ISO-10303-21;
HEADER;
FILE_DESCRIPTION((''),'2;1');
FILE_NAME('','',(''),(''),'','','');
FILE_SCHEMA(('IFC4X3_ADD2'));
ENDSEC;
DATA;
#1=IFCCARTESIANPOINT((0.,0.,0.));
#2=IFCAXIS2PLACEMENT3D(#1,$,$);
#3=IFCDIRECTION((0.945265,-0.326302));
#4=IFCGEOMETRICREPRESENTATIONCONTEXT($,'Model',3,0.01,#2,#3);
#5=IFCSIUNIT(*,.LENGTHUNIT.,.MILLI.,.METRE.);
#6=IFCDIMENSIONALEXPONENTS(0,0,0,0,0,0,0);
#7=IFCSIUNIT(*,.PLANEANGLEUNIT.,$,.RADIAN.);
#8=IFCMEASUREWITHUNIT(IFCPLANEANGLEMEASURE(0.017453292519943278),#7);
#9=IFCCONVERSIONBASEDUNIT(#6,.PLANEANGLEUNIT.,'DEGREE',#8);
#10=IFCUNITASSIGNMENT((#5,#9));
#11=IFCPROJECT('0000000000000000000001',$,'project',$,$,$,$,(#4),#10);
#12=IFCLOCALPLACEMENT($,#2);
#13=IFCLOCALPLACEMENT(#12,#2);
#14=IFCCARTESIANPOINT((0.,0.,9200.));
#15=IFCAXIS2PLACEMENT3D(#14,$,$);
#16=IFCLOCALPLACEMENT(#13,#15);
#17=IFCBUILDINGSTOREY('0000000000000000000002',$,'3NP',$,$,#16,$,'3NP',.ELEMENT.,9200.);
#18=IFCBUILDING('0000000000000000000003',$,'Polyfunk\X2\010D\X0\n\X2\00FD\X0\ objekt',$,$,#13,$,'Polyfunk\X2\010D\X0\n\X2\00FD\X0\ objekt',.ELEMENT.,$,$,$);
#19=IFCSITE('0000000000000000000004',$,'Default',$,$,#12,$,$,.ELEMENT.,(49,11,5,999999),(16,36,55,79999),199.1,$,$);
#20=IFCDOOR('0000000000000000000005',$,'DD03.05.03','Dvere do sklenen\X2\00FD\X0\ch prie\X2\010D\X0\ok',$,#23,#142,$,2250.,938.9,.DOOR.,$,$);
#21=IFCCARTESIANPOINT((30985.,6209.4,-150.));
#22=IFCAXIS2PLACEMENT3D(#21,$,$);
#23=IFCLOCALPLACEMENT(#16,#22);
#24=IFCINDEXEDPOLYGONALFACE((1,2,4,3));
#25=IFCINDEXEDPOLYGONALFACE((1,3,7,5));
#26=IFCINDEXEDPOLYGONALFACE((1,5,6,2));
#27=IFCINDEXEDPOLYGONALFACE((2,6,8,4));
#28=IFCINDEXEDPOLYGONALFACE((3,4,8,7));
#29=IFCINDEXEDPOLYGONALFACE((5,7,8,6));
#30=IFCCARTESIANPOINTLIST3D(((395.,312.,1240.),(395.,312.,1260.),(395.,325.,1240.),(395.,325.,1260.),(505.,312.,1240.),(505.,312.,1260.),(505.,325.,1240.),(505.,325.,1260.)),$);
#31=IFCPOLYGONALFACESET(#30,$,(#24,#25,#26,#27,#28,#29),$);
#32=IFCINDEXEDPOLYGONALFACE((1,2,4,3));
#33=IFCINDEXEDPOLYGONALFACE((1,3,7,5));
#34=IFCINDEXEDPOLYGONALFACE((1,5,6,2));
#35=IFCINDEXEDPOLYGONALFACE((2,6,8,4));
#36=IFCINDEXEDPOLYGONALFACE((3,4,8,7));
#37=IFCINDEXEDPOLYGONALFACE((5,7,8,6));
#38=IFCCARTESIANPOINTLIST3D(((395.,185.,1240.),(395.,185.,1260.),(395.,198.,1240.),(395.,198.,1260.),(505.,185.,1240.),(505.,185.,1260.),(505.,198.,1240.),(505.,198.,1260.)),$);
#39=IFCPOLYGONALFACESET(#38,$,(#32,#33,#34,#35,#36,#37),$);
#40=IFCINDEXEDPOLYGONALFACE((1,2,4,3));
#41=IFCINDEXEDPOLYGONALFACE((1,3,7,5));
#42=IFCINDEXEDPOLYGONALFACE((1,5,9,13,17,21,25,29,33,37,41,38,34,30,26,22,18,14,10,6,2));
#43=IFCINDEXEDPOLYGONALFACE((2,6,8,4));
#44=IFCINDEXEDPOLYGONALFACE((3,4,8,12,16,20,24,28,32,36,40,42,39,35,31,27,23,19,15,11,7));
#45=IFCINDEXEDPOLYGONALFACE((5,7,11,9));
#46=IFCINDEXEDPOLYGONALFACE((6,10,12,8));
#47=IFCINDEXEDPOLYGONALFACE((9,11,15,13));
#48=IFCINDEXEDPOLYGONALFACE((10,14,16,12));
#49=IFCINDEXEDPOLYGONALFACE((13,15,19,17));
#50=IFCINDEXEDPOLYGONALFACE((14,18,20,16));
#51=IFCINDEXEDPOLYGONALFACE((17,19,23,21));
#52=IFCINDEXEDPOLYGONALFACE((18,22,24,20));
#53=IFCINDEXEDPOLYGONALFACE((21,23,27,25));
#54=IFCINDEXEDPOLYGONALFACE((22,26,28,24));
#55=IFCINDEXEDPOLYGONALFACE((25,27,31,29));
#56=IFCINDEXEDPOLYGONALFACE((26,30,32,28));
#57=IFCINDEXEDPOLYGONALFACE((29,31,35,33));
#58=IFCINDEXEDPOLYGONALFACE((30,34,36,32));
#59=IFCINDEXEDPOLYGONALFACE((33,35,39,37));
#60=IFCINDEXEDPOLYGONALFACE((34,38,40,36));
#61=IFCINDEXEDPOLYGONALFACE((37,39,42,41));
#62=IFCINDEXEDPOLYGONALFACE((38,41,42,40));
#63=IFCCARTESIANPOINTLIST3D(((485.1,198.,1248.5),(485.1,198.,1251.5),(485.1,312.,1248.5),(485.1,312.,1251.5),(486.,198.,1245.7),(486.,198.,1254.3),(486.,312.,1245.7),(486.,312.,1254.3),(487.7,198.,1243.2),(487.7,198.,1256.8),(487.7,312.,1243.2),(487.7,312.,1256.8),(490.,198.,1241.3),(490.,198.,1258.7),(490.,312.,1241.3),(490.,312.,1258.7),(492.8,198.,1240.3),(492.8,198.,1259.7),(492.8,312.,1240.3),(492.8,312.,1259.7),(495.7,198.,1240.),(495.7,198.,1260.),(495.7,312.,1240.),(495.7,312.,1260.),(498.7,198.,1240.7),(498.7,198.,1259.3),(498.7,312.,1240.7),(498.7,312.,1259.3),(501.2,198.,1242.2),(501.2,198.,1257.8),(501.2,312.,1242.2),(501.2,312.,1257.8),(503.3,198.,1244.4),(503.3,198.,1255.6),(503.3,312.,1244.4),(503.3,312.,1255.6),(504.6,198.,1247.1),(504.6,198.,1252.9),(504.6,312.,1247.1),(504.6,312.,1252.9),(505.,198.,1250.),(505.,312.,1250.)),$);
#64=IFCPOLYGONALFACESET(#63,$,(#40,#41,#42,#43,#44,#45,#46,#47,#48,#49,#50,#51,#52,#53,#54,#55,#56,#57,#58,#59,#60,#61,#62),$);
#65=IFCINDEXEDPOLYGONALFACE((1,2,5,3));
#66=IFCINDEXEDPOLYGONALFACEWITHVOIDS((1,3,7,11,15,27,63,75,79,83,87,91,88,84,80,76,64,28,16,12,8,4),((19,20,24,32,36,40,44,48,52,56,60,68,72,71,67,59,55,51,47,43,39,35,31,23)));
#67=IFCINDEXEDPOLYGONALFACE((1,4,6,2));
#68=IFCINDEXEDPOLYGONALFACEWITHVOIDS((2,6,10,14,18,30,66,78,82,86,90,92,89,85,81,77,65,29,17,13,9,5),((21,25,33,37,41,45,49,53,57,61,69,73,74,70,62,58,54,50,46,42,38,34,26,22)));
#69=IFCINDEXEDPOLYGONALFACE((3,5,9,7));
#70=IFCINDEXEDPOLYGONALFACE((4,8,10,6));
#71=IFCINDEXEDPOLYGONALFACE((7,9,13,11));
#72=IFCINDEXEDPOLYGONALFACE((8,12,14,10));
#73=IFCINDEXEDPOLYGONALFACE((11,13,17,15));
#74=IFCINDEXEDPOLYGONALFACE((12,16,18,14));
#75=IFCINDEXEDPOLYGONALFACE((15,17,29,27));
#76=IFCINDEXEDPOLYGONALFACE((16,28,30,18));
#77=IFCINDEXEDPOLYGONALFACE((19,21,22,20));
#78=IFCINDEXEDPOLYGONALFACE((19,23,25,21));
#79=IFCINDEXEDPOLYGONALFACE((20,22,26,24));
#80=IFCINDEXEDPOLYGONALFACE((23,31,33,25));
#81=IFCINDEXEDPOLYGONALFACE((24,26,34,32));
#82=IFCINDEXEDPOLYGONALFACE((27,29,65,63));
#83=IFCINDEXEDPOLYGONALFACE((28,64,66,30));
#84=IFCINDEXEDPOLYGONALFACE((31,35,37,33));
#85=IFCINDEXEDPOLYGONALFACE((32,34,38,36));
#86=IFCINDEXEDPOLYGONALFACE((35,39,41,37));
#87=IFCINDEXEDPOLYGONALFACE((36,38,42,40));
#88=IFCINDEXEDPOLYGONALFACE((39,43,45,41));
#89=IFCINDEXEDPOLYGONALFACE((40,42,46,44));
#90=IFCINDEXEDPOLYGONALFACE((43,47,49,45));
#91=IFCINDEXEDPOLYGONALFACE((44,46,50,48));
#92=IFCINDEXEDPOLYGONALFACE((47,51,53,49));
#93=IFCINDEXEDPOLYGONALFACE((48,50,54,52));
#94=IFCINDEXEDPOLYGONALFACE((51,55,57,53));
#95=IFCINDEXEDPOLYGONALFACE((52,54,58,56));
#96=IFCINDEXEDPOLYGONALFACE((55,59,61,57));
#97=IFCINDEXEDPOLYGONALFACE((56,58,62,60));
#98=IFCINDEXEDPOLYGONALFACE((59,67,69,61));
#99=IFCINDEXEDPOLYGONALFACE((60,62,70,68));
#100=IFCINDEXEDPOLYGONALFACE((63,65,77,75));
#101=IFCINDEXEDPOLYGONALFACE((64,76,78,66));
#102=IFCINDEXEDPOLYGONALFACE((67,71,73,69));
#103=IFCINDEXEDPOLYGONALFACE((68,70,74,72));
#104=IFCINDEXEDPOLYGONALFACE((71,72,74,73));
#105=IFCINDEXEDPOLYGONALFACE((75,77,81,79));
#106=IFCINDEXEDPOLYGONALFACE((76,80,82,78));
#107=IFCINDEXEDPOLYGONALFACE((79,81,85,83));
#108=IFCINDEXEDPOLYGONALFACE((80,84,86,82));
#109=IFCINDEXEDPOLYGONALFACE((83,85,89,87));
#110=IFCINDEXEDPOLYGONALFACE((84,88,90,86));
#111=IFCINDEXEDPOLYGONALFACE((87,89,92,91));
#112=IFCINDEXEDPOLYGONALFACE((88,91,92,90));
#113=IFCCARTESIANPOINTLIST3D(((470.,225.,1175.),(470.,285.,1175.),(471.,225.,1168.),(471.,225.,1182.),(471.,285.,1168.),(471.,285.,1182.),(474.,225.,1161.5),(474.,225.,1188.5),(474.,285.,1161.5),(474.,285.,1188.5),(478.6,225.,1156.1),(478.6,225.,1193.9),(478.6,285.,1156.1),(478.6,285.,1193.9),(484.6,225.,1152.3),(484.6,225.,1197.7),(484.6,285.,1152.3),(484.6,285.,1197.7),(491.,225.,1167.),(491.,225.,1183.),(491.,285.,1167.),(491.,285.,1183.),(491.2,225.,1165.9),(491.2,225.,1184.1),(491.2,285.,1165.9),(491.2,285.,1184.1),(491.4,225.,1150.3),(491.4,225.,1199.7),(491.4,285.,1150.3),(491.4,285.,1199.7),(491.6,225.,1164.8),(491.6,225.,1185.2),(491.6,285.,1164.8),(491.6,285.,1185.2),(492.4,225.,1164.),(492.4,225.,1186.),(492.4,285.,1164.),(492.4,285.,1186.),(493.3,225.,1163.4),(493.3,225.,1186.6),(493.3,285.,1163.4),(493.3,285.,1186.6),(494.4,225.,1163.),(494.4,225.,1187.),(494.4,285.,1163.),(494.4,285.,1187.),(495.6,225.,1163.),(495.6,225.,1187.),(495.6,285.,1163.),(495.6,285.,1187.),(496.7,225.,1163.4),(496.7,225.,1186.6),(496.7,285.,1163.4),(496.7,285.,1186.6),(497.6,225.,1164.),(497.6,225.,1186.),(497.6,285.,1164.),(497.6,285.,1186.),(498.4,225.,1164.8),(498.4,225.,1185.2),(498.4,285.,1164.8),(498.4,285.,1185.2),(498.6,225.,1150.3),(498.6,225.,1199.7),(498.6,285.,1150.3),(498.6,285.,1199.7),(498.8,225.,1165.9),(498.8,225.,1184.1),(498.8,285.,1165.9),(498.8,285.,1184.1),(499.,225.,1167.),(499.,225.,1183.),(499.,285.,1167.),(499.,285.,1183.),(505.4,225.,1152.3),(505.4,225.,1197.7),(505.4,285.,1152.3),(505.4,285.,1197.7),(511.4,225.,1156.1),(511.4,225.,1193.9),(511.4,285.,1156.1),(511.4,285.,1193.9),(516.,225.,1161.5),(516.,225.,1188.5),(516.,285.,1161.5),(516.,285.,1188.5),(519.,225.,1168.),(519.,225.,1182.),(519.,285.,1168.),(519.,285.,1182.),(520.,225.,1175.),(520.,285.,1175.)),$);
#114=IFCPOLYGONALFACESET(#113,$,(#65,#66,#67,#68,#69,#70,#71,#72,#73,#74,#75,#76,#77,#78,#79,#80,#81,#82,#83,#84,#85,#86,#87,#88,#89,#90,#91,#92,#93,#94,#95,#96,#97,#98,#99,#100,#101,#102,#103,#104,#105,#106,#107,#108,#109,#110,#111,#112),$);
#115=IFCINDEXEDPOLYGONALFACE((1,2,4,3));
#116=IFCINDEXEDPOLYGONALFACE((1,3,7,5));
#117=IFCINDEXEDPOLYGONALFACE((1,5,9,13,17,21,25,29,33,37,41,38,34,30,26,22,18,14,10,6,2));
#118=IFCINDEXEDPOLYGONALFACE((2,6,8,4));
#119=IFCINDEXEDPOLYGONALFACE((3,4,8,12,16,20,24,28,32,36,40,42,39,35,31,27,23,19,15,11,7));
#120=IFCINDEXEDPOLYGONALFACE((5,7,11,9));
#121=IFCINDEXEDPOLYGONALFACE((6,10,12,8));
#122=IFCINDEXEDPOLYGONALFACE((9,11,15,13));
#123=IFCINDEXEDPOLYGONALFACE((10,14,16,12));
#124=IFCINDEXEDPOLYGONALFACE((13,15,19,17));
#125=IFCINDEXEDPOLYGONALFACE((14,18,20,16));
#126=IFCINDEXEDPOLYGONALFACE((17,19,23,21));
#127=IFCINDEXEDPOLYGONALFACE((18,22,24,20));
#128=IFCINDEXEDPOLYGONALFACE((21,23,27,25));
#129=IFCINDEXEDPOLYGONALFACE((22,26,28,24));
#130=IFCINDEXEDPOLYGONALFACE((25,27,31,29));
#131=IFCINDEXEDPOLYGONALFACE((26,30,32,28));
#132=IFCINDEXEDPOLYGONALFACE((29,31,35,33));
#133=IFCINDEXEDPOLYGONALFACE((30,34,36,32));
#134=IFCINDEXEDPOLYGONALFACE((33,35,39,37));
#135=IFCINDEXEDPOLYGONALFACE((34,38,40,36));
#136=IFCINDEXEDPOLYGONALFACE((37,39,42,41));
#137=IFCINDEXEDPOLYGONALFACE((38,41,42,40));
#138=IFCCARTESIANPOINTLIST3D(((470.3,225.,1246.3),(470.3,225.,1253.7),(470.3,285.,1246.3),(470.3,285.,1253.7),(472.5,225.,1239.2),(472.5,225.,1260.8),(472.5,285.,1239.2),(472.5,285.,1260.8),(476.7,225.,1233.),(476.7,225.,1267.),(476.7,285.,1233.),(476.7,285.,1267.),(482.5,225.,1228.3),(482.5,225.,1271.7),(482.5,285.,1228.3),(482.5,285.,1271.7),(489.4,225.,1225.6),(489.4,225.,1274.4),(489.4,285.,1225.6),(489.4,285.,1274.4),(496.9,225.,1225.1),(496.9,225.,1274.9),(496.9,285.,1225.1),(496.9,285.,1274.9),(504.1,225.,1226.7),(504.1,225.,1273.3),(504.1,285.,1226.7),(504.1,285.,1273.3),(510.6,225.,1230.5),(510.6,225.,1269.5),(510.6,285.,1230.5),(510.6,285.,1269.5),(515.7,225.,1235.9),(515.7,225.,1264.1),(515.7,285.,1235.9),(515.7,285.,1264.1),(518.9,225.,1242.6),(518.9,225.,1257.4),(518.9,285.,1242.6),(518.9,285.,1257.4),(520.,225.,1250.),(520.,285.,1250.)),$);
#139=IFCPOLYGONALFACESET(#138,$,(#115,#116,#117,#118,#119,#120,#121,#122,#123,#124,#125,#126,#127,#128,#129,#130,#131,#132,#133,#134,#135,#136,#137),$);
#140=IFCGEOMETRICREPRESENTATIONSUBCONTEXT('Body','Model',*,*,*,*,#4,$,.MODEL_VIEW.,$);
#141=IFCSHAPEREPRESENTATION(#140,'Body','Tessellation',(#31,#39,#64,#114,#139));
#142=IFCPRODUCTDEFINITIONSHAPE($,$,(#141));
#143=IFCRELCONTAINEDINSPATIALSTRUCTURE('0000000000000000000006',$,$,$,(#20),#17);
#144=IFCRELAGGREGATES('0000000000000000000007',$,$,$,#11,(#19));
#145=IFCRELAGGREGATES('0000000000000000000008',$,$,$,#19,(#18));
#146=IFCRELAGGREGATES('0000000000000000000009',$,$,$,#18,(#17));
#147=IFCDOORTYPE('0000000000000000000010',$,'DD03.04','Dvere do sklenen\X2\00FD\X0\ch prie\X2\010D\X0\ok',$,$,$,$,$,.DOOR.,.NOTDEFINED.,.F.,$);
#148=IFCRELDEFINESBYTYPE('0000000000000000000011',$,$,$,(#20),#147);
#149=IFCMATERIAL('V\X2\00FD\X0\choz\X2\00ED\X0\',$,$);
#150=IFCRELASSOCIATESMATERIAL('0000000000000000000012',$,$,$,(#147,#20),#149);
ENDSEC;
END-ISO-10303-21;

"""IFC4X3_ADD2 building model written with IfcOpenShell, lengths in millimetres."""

from ifc_helpers import new_model, entity, si_unit, converted_unit, direction, frame, frame_2d, origin, origin_2d_with_axis, place, context, subcontext, project, spatial, polyline, circle_curve, parameter, trimmed, segment, composite_curve, rectangle, circle, outline, extrude, source, transform, mapped, material, type_object, type_shapes, element, save


model = new_model("IFC4X3_ADD2")

# Units and contexts
model_context = context("Model", 3, precision=0.01, world=origin(), true_north=direction((0.945265, -0.326302)))
body_context = subcontext(model_context, "Body", "Model", "MODEL_VIEW")
ifc_project = project(units=[si_unit("LENGTHUNIT", "METRE", prefix="MILLI"), converted_unit("PLANEANGLEUNIT", "DEGREE", entity("IfcPlaneAngleMeasure", 0.017453292519943278), si_unit("PLANEANGLEUNIT", "RADIAN"), dimensions=[0, 0, 0, 0, 0, 0, 0])], contexts=[model_context])

# Site, building, storey
site_placement = place(None, origin())
site = spatial("IfcSite", under=ifc_project, at=site_placement, Name="Default", CompositionType="ELEMENT", RefLatitude=(49, 11, 5, 999999), RefLongitude=(16, 36, 55, 79999), RefElevation=199.1)
building_placement = place(site_placement, origin())
building = spatial("IfcBuilding", under=site, at=building_placement, Name="Polyfunkčný objekt", LongName="Polyfunkčný objekt", CompositionType="ELEMENT")
storey_placement = place(building_placement, frame((0.0, 0.0, 9200.0)))
storey = spatial("IfcBuildingStorey", under=building, at=storey_placement, Name="3NP", LongName="3NP", CompositionType="ELEMENT", Elevation=9200.0)

# Door
ifc_material_1 = material(Name="Výchozí")
door_type = type_object("IfcDoorType", Name="DD03.04", Description="Dvere do sklenených priečok", OperationType="NOTDEFINED", ParameterTakesPrecedence=False, PredefinedType="DOOR", material=ifc_material_1)
shared_shape_1 = source(origin(), body_context, "Body", "SweptSolid", [
    extrude(rectangle(XDim=13.0, YDim=110.0, at=frame_2d((0.0, 0.0), x_axis=(1.0, 0.0))), frame((450.0, 318.5, 1240.0), z_axis=(0.0, 0.0, 1.0), x_axis=(0.0, 1.0, 0.0)), (0.0, 0.0, 1.0), 20.0),
    extrude(rectangle(XDim=13.0, YDim=110.0, at=frame_2d((0.0, 0.0), x_axis=(1.0, 0.0))), frame((450.0, 191.5, 1240.0), z_axis=(0.0, 0.0, 1.0), x_axis=(0.0, -1.0, 0.0)), (0.0, 0.0, 1.0), 20.0),
    extrude(circle(Radius=10.0, at=origin_2d_with_axis()), frame((495.0, 312.0, 1250.0), z_axis=(0.0, -1.0, 0.0), x_axis=(1.0, 0.0, 0.0)), (0.0, 0.0, 1.0), 114.0),
    extrude(outline(composite_curve([segment(trimmed(circle_curve(origin_2d_with_axis(), 25.0), [parameter(180.0)], [parameter(360.0)], True, "PARAMETER"), True, "CONTINUOUS"), segment(trimmed(circle_curve(origin_2d_with_axis(), 25.0), [parameter(0.0)], [parameter(180.0)], True, "PARAMETER"), True, "CONTINUOUS")], self_intersect=False), holes=[composite_curve([segment(trimmed(circle_curve(frame_2d((0.0, 8.0), x_axis=(1.0, 0.0)), 4.0), [parameter(0.0)], [parameter(180.0)], True, "PARAMETER"), False, "CONTINUOUS"), segment(polyline([(4.0, 8.0), (4.0, -8.0)]), True, "CONTINUOUS"), segment(trimmed(circle_curve(frame_2d((0.0, -8.0), x_axis=(1.0, 0.0)), 4.0), [parameter(180.0)], [parameter(0.0)], True, "PARAMETER"), False, "CONTINUOUS"), segment(polyline([(-4.0, -8.0), (-4.0, 8.0)]), True, "CONTINUOUS")], self_intersect=False)]), frame((495.0, 285.0, 1175.0), z_axis=(0.0, -1.0, 0.0), x_axis=(1.0, 0.0, 0.0)), (0.0, 0.0, 1.0), 60.0),
    extrude(circle(Radius=25.0, at=frame_2d((0.0, 0.0), x_axis=(1.0, 0.0))), frame((495.0, 285.0, 1250.0), z_axis=(0.0, -1.0, 0.0), x_axis=(1.0, 0.0, 0.0)), (0.0, 0.0, 1.0), 60.0),
])
type_shapes(door_type, [shared_shape_1])
door_placement = place(storey_placement, frame((30985.0, 6209.4, -150.0)))
element("IfcDoor", 1, at=door_placement, inside=storey, type_object=door_type, material=ifc_material_1, Name="DD03.05.03", Description="Dvere do sklenených priečok", OverallHeight=2250.0, OverallWidth=938.9, PredefinedType="DOOR", context=body_context, shape_type="MappedRepresentation", body=[
    mapped(shared_shape_1, transform((0.0, 0.0, 0.0), scale=1.0)),
])

save(model, "model.ifc")
